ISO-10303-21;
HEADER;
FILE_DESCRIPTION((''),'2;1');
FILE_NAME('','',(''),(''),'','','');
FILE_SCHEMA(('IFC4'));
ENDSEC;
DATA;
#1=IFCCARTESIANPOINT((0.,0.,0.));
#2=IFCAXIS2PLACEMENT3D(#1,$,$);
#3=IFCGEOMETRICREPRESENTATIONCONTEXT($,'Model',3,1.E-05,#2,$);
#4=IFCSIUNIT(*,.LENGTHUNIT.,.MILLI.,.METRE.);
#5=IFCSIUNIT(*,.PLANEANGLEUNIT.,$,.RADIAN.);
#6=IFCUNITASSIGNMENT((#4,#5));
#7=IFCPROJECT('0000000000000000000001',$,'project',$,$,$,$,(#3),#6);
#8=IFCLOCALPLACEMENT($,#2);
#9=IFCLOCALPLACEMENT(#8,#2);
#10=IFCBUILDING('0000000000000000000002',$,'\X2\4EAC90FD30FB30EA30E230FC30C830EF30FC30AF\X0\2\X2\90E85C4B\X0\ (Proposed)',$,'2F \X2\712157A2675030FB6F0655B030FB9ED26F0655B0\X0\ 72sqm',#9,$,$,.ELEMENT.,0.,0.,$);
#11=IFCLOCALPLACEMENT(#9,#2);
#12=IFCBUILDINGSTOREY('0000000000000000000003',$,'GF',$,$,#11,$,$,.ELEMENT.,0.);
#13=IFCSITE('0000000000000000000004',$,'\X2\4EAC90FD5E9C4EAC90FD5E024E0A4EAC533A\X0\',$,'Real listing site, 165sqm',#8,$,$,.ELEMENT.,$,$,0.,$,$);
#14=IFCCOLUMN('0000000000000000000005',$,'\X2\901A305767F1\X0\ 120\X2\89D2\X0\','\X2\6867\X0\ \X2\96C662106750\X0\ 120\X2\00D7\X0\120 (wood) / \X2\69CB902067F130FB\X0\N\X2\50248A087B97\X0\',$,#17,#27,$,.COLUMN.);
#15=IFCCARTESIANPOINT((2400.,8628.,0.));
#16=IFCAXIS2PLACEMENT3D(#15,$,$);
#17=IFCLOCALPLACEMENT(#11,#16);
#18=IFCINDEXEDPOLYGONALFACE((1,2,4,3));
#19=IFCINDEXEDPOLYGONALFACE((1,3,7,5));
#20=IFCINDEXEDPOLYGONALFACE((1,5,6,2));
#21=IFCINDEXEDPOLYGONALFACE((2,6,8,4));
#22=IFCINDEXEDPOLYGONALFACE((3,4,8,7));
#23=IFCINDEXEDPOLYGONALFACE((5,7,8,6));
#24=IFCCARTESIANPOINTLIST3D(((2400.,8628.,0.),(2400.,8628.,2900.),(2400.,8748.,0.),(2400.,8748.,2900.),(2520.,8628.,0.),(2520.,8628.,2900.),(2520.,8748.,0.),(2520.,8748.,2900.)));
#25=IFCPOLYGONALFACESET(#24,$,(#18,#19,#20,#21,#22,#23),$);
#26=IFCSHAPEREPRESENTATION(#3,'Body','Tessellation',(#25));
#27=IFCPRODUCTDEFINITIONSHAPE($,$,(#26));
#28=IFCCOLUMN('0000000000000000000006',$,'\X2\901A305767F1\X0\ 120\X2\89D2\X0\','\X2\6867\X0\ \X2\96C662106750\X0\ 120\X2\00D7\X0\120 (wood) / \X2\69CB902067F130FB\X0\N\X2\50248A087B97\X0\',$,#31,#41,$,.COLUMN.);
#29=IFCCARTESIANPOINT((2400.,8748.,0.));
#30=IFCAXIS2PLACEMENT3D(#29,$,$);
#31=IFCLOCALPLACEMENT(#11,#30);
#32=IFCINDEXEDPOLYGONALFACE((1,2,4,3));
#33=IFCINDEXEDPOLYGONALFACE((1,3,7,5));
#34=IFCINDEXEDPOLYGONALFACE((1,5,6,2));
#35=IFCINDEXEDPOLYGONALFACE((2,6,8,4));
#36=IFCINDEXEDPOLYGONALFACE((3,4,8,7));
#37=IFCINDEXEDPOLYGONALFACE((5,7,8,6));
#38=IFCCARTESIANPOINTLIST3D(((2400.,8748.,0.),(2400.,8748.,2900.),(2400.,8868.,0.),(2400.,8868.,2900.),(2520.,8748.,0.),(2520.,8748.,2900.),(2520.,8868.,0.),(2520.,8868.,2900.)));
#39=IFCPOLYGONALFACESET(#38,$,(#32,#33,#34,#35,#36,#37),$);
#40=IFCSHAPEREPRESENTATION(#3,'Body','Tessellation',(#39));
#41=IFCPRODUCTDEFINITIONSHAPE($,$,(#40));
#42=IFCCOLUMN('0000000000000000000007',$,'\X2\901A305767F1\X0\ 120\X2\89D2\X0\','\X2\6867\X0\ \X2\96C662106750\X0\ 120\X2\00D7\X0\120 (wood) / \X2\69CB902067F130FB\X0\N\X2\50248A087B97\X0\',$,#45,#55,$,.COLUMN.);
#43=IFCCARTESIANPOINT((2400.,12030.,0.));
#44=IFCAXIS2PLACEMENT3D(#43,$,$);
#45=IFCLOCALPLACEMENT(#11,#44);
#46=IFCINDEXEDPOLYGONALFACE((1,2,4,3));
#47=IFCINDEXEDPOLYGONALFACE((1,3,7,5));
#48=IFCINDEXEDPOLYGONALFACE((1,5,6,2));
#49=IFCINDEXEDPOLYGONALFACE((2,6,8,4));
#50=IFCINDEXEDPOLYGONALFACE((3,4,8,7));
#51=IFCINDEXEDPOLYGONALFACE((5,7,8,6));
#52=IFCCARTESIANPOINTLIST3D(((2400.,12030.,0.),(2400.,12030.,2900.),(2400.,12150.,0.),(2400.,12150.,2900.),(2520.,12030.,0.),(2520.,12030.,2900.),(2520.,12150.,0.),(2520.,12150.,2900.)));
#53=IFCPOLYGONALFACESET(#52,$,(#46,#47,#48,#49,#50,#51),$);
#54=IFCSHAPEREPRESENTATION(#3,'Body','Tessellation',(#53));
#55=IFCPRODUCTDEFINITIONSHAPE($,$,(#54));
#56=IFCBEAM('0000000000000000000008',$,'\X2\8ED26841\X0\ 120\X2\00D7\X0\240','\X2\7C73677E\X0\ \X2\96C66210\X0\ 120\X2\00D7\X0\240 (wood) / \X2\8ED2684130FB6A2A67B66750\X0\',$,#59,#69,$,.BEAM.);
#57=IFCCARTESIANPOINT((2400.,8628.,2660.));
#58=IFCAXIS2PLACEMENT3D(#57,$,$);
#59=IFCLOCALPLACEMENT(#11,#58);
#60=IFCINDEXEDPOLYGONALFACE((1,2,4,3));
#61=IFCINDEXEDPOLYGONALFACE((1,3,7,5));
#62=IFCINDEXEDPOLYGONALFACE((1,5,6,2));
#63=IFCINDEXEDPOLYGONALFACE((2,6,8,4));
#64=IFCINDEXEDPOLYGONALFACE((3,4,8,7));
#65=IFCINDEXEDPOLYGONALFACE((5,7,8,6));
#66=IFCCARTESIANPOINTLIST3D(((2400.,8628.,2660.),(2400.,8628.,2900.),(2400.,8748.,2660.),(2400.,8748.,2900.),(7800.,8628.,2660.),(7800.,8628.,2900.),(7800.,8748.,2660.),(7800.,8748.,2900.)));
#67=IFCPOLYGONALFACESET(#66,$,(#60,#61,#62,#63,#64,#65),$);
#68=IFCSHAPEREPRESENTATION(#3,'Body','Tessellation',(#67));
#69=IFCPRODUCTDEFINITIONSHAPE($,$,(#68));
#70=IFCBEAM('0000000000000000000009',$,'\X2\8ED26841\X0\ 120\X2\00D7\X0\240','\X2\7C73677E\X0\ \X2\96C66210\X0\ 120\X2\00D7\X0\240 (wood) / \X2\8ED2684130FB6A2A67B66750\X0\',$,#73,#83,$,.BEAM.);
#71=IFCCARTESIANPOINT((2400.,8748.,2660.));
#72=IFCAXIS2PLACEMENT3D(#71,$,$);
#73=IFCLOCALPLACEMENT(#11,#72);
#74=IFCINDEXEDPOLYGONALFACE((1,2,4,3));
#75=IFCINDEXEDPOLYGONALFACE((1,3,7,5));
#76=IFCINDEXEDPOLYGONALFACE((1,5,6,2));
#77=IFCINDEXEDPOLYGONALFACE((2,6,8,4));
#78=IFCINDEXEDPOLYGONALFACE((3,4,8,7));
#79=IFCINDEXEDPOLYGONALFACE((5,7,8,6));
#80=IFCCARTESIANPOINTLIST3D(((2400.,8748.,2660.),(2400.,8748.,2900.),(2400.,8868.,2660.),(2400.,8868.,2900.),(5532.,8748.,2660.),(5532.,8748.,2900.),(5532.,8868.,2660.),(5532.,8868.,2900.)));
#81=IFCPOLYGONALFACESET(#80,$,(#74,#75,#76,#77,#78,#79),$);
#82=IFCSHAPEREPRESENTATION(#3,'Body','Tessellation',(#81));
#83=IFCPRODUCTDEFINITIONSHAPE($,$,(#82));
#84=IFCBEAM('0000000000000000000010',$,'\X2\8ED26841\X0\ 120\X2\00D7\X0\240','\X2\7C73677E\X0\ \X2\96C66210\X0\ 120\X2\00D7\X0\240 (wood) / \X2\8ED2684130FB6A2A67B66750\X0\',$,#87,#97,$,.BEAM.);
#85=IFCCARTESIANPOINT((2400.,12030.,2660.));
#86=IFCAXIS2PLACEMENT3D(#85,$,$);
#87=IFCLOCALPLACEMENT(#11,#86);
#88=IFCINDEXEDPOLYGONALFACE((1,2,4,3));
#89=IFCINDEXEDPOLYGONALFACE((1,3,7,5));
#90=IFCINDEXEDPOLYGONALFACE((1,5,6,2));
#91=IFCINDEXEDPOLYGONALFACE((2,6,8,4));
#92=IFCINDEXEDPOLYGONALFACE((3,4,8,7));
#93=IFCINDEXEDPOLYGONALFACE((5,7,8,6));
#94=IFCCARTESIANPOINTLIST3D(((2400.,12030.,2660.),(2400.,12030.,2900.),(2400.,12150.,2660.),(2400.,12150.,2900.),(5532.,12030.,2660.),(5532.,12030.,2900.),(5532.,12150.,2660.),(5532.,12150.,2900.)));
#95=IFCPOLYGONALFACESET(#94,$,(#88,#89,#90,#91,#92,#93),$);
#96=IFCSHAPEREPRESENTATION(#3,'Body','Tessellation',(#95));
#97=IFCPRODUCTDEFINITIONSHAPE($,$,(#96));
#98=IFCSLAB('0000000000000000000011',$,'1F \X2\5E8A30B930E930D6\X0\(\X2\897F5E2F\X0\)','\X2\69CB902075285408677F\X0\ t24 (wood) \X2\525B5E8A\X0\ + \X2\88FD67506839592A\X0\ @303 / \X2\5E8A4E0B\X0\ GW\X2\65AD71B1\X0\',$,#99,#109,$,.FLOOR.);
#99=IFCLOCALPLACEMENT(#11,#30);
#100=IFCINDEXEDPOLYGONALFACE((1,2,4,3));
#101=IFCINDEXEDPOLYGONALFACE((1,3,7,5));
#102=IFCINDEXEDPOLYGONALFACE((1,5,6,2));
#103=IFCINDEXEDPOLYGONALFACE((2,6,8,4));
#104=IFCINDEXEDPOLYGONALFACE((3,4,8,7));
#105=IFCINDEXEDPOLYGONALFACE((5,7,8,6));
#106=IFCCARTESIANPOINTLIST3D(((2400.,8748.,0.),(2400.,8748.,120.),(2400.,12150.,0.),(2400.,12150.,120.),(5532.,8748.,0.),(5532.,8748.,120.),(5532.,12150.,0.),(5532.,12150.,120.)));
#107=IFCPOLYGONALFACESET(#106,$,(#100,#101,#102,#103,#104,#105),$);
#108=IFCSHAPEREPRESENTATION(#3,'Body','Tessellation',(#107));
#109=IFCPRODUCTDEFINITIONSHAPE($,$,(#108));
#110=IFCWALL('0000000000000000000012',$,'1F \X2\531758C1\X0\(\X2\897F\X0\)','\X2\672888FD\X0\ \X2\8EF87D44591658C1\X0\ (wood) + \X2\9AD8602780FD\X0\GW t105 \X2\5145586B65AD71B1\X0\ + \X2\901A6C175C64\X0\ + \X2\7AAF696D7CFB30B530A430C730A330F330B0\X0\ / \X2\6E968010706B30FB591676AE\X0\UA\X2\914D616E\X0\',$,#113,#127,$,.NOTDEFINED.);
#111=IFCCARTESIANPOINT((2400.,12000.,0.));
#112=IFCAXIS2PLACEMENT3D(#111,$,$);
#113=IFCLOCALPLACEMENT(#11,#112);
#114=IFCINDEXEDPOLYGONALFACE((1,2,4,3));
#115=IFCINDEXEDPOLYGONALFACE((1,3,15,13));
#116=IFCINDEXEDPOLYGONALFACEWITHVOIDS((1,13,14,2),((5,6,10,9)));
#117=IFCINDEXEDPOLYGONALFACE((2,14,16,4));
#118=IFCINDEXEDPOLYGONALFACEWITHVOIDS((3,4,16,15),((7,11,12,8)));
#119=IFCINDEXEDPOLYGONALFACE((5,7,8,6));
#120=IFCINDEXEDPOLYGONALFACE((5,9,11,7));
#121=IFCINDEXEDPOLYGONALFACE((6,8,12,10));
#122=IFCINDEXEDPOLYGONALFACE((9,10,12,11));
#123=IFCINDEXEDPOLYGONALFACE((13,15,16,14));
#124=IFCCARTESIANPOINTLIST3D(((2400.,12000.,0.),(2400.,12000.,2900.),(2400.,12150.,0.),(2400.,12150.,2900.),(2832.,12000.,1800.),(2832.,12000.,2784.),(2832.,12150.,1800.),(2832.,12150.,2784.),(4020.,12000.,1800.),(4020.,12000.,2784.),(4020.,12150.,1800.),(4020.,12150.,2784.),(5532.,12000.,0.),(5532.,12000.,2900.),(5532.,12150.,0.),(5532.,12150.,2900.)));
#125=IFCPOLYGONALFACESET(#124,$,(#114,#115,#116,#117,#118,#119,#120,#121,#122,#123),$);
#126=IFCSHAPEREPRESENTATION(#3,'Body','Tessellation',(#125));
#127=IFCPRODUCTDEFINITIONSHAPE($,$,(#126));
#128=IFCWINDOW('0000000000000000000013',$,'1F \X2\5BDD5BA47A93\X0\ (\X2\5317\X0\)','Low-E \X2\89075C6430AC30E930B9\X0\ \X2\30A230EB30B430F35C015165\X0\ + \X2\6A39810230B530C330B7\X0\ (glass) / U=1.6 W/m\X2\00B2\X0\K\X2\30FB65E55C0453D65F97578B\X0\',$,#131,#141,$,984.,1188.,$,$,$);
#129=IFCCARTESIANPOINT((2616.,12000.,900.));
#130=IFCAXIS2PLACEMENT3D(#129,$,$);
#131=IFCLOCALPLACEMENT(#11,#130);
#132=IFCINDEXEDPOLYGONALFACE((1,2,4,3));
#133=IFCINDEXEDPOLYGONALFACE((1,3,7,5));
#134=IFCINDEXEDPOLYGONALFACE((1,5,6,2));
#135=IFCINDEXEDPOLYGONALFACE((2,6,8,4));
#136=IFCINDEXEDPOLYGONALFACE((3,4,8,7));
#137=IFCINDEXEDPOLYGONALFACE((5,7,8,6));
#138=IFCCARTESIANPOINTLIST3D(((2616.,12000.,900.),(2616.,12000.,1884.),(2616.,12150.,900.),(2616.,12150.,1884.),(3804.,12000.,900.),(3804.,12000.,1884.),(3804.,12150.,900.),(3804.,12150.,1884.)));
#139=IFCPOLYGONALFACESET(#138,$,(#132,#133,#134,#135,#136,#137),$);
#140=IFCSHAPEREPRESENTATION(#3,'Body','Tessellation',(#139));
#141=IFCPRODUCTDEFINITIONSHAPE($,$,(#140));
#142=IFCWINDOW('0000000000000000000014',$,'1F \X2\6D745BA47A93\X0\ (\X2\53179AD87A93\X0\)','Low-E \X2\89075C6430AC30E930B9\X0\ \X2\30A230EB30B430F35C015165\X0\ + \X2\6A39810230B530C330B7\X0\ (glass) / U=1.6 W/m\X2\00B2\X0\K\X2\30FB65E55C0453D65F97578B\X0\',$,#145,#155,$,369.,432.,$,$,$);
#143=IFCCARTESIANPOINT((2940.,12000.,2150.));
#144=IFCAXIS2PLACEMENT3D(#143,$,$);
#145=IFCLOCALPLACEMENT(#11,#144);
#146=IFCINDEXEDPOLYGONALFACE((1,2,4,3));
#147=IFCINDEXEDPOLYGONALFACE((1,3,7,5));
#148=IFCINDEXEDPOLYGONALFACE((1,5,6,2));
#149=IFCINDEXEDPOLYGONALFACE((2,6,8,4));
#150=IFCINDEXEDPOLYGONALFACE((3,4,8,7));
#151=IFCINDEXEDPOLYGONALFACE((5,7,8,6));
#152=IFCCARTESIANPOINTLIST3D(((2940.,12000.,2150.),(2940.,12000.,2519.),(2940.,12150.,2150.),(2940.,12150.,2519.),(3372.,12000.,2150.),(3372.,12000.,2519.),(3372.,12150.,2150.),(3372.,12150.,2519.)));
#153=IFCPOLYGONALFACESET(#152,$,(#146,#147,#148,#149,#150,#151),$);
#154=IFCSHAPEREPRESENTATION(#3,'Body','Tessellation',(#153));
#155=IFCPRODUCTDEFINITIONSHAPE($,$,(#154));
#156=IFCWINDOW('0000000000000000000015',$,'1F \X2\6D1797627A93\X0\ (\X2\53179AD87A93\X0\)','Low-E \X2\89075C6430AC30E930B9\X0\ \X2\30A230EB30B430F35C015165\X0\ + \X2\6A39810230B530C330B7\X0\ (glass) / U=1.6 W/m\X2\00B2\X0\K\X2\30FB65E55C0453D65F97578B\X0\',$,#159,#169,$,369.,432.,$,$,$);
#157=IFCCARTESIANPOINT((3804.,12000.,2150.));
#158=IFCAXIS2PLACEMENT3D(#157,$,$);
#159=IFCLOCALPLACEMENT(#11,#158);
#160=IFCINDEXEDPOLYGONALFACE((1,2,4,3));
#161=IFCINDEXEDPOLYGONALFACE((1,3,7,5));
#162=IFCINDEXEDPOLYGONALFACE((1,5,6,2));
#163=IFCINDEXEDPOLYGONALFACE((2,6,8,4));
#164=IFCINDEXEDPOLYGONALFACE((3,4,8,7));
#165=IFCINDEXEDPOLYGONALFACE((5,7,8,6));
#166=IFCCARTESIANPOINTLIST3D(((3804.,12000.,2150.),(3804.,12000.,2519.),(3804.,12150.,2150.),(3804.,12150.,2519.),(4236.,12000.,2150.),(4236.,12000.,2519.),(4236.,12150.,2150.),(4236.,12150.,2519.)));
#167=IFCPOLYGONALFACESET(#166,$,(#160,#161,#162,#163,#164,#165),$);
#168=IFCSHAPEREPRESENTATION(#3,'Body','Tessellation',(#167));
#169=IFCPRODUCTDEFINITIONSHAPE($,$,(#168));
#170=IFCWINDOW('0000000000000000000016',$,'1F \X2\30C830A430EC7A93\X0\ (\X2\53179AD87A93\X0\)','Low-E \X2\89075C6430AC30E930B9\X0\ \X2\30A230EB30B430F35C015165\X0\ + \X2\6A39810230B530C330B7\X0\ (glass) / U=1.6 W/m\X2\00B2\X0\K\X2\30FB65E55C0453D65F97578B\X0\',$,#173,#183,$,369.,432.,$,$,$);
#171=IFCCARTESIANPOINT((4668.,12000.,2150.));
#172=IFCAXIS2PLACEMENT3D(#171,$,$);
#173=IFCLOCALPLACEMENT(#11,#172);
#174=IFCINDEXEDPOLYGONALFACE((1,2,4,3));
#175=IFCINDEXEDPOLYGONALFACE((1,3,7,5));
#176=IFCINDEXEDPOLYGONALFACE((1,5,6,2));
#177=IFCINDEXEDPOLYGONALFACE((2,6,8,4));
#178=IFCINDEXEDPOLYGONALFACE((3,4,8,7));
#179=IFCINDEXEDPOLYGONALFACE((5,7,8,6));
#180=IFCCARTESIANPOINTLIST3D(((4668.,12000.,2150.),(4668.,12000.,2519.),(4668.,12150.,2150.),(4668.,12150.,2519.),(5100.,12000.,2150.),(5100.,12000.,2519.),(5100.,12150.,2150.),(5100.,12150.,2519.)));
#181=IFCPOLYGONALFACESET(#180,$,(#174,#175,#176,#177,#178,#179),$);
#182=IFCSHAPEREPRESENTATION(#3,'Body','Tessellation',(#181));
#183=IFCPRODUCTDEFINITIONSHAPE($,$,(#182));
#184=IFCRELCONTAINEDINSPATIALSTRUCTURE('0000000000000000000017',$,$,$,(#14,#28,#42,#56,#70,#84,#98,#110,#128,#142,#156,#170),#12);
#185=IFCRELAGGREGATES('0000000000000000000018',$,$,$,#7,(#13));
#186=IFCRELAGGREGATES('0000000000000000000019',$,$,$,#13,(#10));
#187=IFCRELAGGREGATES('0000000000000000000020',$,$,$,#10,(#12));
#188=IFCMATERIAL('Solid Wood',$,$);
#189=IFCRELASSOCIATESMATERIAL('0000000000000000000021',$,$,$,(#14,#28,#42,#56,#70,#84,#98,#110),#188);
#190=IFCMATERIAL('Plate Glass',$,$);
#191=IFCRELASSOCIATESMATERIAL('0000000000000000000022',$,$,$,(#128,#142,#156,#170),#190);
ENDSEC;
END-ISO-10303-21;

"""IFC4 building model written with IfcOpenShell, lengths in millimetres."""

from ifc_helpers import new_model, si_unit, frame, frame_2d, origin, place, context, project, spatial, rectangle, extrude, material, element, fill, save


model = new_model("IFC4")

# Units and contexts
model_context = context("Model", 3, precision=1e-05, world=origin())
ifc_project = project(units=[si_unit("LENGTHUNIT", "METRE", prefix="MILLI"), si_unit("PLANEANGLEUNIT", "RADIAN")], contexts=[model_context])

# Site, building, storey
site_placement = place(None, origin())
site = spatial("IfcSite", under=ifc_project, at=site_placement, Name="京都府京都市上京区", ObjectType="Real listing site, 165sqm", CompositionType="ELEMENT", RefElevation=0.0)
building_placement = place(site_placement, origin())
building = spatial("IfcBuilding", under=site, at=building_placement, Name="京都・リモートワーク2部屋 (Proposed)", ObjectType="2F 無垢材・漆喰・黒漆喰 72sqm", CompositionType="ELEMENT", ElevationOfRefHeight=0.0, ElevationOfTerrain=0.0)
storey_placement = place(building_placement, origin())
storey = spatial("IfcBuildingStorey", under=building, at=storey_placement, Name="GF", CompositionType="ELEMENT", Elevation=0.0)

# Columns
ifc_material_1 = material(Name="Solid Wood")
column_1_placement = place(storey_placement, frame((2400.0, 8628.0, 0.0)))
element("IfcColumn", 1, at=column_1_placement, inside=storey, material=ifc_material_1, Name="通し柱 120角", Description="桧 集成材 120×120 (wood) / 構造柱・N値計算", PredefinedType="COLUMN", context=model_context, shape_type="SweptSolid", body=[
    extrude(rectangle(XDim=120.0, YDim=120.0, at=frame_2d((60.0, 60.0))), frame((2400.0, 8628.0, 0.0)), (0.0, 0.0, 1.0), 2900.0),
])
column_2_placement = place(storey_placement, frame((2400.0, 8748.0, 0.0)))
element("IfcColumn", 2, at=column_2_placement, inside=storey, material=ifc_material_1, Name="通し柱 120角", Description="桧 集成材 120×120 (wood) / 構造柱・N値計算", PredefinedType="COLUMN", context=model_context, shape_type="SweptSolid", body=[
    extrude(rectangle(XDim=120.0, YDim=120.0, at=frame_2d((60.0, 60.0))), frame((2400.0, 8748.0, 0.0)), (0.0, 0.0, 1.0), 2900.0),
])
column_3_placement = place(storey_placement, frame((2400.0, 12030.0, 0.0)))
element("IfcColumn", 3, at=column_3_placement, inside=storey, material=ifc_material_1, Name="通し柱 120角", Description="桧 集成材 120×120 (wood) / 構造柱・N値計算", PredefinedType="COLUMN", context=model_context, shape_type="SweptSolid", body=[
    extrude(rectangle(XDim=120.0, YDim=120.0, at=frame_2d((60.0, 60.0))), frame((2400.0, 12030.0, 0.0)), (0.0, 0.0, 1.0), 2900.0),
])

# Beams
beam_1_placement = place(storey_placement, frame((2400.0, 8628.0, 2660.0)))
element("IfcBeam", 4, at=beam_1_placement, inside=storey, material=ifc_material_1, Name="軒桁 120×240", Description="米松 集成 120×240 (wood) / 軒桁・横架材", PredefinedType="BEAM", context=model_context, shape_type="SweptSolid", body=[
    extrude(rectangle(XDim=5400.0, YDim=120.0, at=frame_2d((2700.0, 60.0))), frame((2400.0, 8628.0, 2660.0)), (0.0, 0.0, 1.0), 240.0),
])
beam_2_placement = place(storey_placement, frame((2400.0, 8748.0, 2660.0)))
element("IfcBeam", 5, at=beam_2_placement, inside=storey, material=ifc_material_1, Name="軒桁 120×240", Description="米松 集成 120×240 (wood) / 軒桁・横架材", PredefinedType="BEAM", context=model_context, shape_type="SweptSolid", body=[
    extrude(rectangle(XDim=3132.0, YDim=120.0, at=frame_2d((1566.0, 60.0))), frame((2400.0, 8748.0, 2660.0)), (0.0, 0.0, 1.0), 240.0),
])
beam_3_placement = place(storey_placement, frame((2400.0, 12030.0, 2660.0)))
element("IfcBeam", 6, at=beam_3_placement, inside=storey, material=ifc_material_1, Name="軒桁 120×240", Description="米松 集成 120×240 (wood) / 軒桁・横架材", PredefinedType="BEAM", context=model_context, shape_type="SweptSolid", body=[
    extrude(rectangle(XDim=3132.0, YDim=120.0, at=frame_2d((1566.0, 60.0))), frame((2400.0, 12030.0, 2660.0)), (0.0, 0.0, 1.0), 240.0),
])

# Slab
slab_placement = place(storey_placement, frame((2400.0, 8748.0, 0.0)))
element("IfcSlab", 7, at=slab_placement, inside=storey, material=ifc_material_1, Name="1F 床スラブ(西帯)", Description="構造用合板 t24 (wood) 剛床 + 製材根太 @303 / 床下 GW断熱", PredefinedType="FLOOR", context=model_context, shape_type="SweptSolid", body=[
    extrude(rectangle(XDim=3132.0, YDim=3402.0, at=frame_2d((1566.0, 1701.0))), frame((2400.0, 8748.0, 0.0)), (0.0, 0.0, 1.0), 120.0),
])

# Wall, openings, windows
wall_1_placement = place(storey_placement, frame((2400.0, 12000.0, 0.0)))
wall_1 = element("IfcWall", 8, at=wall_1_placement, inside=storey, material=ifc_material_1, Name="1F 北壁(西)", Description="木製 軸組外壁 (wood) + 高性能GW t105 充填断熱 + 通気層 + 窯業系サイディング / 準耐火・外皮UA配慮", PredefinedType="NOTDEFINED", context=model_context, shape_type="SweptSolid", body=[
    extrude(rectangle(XDim=3132.0, YDim=150.0, at=frame_2d((1566.0, 75.0))), frame((2400.0, 12000.0, 0.0)), (0.0, 0.0, 1.0), 2900.0),
])
opening_1_placement = place(storey_placement, frame((2616.0, 12000.0, 900.0)))
opening_1 = element("IfcOpeningElement", 9, at=opening_1_placement, cuts=wall_1, PredefinedType="NOTDEFINED", context=model_context, shape_type="SweptSolid", body=[
    extrude(rectangle(XDim=1188.0, YDim=150.0, at=frame_2d((594.0, 75.0))), frame((2616.0, 12000.0, 900.0)), (0.0, 0.0, 1.0), 984.0),
])
opening_2_placement = place(storey_placement, frame((2940.0, 12000.0, 2150.0)))
opening_2 = element("IfcOpeningElement", 10, at=opening_2_placement, cuts=wall_1, PredefinedType="NOTDEFINED", context=model_context, shape_type="SweptSolid", body=[
    extrude(rectangle(XDim=432.0, YDim=150.0, at=frame_2d((216.0, 75.0))), frame((2940.0, 12000.0, 2150.0)), (0.0, 0.0, 1.0), 369.0),
])
opening_3_placement = place(storey_placement, frame((3804.0, 12000.0, 2150.0)))
opening_3 = element("IfcOpeningElement", 11, at=opening_3_placement, cuts=wall_1, PredefinedType="NOTDEFINED", context=model_context, shape_type="SweptSolid", body=[
    extrude(rectangle(XDim=432.0, YDim=150.0, at=frame_2d((216.0, 75.0))), frame((3804.0, 12000.0, 2150.0)), (0.0, 0.0, 1.0), 369.0),
])
opening_4_placement = place(storey_placement, frame((4668.0, 12000.0, 2150.0)))
opening_4 = element("IfcOpeningElement", 12, at=opening_4_placement, cuts=wall_1, PredefinedType="NOTDEFINED", context=model_context, shape_type="SweptSolid", body=[
    extrude(rectangle(XDim=432.0, YDim=150.0, at=frame_2d((216.0, 75.0))), frame((4668.0, 12000.0, 2150.0)), (0.0, 0.0, 1.0), 369.0),
])
ifc_material_2 = material(Name="Plate Glass")
window_1_placement = place(storey_placement, frame((2616.0, 12000.0, 900.0)))
window_1 = element("IfcWindow", 13, at=window_1_placement, inside=storey, material=ifc_material_2, Name="1F 寝室窓 (北)", Description="Low-E 複層ガラス アルゴン封入 + 樹脂サッシ (glass) / U=1.6 W/m²K・日射取得型", OverallHeight=984.0, OverallWidth=1188.0, context=model_context, shape_type="SweptSolid", body=[
    extrude(rectangle(XDim=1188.0, YDim=150.0, at=frame_2d((594.0, 75.0))), frame((2616.0, 12000.0, 900.0)), (0.0, 0.0, 1.0), 984.0),
])
fill(opening_1, window_1)
window_2_placement = place(storey_placement, frame((2940.0, 12000.0, 2150.0)))
window_2 = element("IfcWindow", 14, at=window_2_placement, inside=storey, material=ifc_material_2, Name="1F 浴室窓 (北高窓)", Description="Low-E 複層ガラス アルゴン封入 + 樹脂サッシ (glass) / U=1.6 W/m²K・日射取得型", OverallHeight=369.0, OverallWidth=432.0, context=model_context, shape_type="SweptSolid", body=[
    extrude(rectangle(XDim=432.0, YDim=150.0, at=frame_2d((216.0, 75.0))), frame((2940.0, 12000.0, 2150.0)), (0.0, 0.0, 1.0), 369.0),
])
fill(opening_2, window_2)
window_3_placement = place(storey_placement, frame((3804.0, 12000.0, 2150.0)))
window_3 = element("IfcWindow", 15, at=window_3_placement, inside=storey, material=ifc_material_2, Name="1F 洗面窓 (北高窓)", Description="Low-E 複層ガラス アルゴン封入 + 樹脂サッシ (glass) / U=1.6 W/m²K・日射取得型", OverallHeight=369.0, OverallWidth=432.0, context=model_context, shape_type="SweptSolid", body=[
    extrude(rectangle(XDim=432.0, YDim=150.0, at=frame_2d((216.0, 75.0))), frame((3804.0, 12000.0, 2150.0)), (0.0, 0.0, 1.0), 369.0),
])
fill(opening_3, window_3)
window_4_placement = place(storey_placement, frame((4668.0, 12000.0, 2150.0)))
window_4 = element("IfcWindow", 16, at=window_4_placement, inside=storey, material=ifc_material_2, Name="1F トイレ窓 (北高窓)", Description="Low-E 複層ガラス アルゴン封入 + 樹脂サッシ (glass) / U=1.6 W/m²K・日射取得型", OverallHeight=369.0, OverallWidth=432.0, context=model_context, shape_type="SweptSolid", body=[
    extrude(rectangle(XDim=432.0, YDim=150.0, at=frame_2d((216.0, 75.0))), frame((4668.0, 12000.0, 2150.0)), (0.0, 0.0, 1.0), 369.0),
])
fill(opening_4, window_4)

save(model, "model.ifc")
